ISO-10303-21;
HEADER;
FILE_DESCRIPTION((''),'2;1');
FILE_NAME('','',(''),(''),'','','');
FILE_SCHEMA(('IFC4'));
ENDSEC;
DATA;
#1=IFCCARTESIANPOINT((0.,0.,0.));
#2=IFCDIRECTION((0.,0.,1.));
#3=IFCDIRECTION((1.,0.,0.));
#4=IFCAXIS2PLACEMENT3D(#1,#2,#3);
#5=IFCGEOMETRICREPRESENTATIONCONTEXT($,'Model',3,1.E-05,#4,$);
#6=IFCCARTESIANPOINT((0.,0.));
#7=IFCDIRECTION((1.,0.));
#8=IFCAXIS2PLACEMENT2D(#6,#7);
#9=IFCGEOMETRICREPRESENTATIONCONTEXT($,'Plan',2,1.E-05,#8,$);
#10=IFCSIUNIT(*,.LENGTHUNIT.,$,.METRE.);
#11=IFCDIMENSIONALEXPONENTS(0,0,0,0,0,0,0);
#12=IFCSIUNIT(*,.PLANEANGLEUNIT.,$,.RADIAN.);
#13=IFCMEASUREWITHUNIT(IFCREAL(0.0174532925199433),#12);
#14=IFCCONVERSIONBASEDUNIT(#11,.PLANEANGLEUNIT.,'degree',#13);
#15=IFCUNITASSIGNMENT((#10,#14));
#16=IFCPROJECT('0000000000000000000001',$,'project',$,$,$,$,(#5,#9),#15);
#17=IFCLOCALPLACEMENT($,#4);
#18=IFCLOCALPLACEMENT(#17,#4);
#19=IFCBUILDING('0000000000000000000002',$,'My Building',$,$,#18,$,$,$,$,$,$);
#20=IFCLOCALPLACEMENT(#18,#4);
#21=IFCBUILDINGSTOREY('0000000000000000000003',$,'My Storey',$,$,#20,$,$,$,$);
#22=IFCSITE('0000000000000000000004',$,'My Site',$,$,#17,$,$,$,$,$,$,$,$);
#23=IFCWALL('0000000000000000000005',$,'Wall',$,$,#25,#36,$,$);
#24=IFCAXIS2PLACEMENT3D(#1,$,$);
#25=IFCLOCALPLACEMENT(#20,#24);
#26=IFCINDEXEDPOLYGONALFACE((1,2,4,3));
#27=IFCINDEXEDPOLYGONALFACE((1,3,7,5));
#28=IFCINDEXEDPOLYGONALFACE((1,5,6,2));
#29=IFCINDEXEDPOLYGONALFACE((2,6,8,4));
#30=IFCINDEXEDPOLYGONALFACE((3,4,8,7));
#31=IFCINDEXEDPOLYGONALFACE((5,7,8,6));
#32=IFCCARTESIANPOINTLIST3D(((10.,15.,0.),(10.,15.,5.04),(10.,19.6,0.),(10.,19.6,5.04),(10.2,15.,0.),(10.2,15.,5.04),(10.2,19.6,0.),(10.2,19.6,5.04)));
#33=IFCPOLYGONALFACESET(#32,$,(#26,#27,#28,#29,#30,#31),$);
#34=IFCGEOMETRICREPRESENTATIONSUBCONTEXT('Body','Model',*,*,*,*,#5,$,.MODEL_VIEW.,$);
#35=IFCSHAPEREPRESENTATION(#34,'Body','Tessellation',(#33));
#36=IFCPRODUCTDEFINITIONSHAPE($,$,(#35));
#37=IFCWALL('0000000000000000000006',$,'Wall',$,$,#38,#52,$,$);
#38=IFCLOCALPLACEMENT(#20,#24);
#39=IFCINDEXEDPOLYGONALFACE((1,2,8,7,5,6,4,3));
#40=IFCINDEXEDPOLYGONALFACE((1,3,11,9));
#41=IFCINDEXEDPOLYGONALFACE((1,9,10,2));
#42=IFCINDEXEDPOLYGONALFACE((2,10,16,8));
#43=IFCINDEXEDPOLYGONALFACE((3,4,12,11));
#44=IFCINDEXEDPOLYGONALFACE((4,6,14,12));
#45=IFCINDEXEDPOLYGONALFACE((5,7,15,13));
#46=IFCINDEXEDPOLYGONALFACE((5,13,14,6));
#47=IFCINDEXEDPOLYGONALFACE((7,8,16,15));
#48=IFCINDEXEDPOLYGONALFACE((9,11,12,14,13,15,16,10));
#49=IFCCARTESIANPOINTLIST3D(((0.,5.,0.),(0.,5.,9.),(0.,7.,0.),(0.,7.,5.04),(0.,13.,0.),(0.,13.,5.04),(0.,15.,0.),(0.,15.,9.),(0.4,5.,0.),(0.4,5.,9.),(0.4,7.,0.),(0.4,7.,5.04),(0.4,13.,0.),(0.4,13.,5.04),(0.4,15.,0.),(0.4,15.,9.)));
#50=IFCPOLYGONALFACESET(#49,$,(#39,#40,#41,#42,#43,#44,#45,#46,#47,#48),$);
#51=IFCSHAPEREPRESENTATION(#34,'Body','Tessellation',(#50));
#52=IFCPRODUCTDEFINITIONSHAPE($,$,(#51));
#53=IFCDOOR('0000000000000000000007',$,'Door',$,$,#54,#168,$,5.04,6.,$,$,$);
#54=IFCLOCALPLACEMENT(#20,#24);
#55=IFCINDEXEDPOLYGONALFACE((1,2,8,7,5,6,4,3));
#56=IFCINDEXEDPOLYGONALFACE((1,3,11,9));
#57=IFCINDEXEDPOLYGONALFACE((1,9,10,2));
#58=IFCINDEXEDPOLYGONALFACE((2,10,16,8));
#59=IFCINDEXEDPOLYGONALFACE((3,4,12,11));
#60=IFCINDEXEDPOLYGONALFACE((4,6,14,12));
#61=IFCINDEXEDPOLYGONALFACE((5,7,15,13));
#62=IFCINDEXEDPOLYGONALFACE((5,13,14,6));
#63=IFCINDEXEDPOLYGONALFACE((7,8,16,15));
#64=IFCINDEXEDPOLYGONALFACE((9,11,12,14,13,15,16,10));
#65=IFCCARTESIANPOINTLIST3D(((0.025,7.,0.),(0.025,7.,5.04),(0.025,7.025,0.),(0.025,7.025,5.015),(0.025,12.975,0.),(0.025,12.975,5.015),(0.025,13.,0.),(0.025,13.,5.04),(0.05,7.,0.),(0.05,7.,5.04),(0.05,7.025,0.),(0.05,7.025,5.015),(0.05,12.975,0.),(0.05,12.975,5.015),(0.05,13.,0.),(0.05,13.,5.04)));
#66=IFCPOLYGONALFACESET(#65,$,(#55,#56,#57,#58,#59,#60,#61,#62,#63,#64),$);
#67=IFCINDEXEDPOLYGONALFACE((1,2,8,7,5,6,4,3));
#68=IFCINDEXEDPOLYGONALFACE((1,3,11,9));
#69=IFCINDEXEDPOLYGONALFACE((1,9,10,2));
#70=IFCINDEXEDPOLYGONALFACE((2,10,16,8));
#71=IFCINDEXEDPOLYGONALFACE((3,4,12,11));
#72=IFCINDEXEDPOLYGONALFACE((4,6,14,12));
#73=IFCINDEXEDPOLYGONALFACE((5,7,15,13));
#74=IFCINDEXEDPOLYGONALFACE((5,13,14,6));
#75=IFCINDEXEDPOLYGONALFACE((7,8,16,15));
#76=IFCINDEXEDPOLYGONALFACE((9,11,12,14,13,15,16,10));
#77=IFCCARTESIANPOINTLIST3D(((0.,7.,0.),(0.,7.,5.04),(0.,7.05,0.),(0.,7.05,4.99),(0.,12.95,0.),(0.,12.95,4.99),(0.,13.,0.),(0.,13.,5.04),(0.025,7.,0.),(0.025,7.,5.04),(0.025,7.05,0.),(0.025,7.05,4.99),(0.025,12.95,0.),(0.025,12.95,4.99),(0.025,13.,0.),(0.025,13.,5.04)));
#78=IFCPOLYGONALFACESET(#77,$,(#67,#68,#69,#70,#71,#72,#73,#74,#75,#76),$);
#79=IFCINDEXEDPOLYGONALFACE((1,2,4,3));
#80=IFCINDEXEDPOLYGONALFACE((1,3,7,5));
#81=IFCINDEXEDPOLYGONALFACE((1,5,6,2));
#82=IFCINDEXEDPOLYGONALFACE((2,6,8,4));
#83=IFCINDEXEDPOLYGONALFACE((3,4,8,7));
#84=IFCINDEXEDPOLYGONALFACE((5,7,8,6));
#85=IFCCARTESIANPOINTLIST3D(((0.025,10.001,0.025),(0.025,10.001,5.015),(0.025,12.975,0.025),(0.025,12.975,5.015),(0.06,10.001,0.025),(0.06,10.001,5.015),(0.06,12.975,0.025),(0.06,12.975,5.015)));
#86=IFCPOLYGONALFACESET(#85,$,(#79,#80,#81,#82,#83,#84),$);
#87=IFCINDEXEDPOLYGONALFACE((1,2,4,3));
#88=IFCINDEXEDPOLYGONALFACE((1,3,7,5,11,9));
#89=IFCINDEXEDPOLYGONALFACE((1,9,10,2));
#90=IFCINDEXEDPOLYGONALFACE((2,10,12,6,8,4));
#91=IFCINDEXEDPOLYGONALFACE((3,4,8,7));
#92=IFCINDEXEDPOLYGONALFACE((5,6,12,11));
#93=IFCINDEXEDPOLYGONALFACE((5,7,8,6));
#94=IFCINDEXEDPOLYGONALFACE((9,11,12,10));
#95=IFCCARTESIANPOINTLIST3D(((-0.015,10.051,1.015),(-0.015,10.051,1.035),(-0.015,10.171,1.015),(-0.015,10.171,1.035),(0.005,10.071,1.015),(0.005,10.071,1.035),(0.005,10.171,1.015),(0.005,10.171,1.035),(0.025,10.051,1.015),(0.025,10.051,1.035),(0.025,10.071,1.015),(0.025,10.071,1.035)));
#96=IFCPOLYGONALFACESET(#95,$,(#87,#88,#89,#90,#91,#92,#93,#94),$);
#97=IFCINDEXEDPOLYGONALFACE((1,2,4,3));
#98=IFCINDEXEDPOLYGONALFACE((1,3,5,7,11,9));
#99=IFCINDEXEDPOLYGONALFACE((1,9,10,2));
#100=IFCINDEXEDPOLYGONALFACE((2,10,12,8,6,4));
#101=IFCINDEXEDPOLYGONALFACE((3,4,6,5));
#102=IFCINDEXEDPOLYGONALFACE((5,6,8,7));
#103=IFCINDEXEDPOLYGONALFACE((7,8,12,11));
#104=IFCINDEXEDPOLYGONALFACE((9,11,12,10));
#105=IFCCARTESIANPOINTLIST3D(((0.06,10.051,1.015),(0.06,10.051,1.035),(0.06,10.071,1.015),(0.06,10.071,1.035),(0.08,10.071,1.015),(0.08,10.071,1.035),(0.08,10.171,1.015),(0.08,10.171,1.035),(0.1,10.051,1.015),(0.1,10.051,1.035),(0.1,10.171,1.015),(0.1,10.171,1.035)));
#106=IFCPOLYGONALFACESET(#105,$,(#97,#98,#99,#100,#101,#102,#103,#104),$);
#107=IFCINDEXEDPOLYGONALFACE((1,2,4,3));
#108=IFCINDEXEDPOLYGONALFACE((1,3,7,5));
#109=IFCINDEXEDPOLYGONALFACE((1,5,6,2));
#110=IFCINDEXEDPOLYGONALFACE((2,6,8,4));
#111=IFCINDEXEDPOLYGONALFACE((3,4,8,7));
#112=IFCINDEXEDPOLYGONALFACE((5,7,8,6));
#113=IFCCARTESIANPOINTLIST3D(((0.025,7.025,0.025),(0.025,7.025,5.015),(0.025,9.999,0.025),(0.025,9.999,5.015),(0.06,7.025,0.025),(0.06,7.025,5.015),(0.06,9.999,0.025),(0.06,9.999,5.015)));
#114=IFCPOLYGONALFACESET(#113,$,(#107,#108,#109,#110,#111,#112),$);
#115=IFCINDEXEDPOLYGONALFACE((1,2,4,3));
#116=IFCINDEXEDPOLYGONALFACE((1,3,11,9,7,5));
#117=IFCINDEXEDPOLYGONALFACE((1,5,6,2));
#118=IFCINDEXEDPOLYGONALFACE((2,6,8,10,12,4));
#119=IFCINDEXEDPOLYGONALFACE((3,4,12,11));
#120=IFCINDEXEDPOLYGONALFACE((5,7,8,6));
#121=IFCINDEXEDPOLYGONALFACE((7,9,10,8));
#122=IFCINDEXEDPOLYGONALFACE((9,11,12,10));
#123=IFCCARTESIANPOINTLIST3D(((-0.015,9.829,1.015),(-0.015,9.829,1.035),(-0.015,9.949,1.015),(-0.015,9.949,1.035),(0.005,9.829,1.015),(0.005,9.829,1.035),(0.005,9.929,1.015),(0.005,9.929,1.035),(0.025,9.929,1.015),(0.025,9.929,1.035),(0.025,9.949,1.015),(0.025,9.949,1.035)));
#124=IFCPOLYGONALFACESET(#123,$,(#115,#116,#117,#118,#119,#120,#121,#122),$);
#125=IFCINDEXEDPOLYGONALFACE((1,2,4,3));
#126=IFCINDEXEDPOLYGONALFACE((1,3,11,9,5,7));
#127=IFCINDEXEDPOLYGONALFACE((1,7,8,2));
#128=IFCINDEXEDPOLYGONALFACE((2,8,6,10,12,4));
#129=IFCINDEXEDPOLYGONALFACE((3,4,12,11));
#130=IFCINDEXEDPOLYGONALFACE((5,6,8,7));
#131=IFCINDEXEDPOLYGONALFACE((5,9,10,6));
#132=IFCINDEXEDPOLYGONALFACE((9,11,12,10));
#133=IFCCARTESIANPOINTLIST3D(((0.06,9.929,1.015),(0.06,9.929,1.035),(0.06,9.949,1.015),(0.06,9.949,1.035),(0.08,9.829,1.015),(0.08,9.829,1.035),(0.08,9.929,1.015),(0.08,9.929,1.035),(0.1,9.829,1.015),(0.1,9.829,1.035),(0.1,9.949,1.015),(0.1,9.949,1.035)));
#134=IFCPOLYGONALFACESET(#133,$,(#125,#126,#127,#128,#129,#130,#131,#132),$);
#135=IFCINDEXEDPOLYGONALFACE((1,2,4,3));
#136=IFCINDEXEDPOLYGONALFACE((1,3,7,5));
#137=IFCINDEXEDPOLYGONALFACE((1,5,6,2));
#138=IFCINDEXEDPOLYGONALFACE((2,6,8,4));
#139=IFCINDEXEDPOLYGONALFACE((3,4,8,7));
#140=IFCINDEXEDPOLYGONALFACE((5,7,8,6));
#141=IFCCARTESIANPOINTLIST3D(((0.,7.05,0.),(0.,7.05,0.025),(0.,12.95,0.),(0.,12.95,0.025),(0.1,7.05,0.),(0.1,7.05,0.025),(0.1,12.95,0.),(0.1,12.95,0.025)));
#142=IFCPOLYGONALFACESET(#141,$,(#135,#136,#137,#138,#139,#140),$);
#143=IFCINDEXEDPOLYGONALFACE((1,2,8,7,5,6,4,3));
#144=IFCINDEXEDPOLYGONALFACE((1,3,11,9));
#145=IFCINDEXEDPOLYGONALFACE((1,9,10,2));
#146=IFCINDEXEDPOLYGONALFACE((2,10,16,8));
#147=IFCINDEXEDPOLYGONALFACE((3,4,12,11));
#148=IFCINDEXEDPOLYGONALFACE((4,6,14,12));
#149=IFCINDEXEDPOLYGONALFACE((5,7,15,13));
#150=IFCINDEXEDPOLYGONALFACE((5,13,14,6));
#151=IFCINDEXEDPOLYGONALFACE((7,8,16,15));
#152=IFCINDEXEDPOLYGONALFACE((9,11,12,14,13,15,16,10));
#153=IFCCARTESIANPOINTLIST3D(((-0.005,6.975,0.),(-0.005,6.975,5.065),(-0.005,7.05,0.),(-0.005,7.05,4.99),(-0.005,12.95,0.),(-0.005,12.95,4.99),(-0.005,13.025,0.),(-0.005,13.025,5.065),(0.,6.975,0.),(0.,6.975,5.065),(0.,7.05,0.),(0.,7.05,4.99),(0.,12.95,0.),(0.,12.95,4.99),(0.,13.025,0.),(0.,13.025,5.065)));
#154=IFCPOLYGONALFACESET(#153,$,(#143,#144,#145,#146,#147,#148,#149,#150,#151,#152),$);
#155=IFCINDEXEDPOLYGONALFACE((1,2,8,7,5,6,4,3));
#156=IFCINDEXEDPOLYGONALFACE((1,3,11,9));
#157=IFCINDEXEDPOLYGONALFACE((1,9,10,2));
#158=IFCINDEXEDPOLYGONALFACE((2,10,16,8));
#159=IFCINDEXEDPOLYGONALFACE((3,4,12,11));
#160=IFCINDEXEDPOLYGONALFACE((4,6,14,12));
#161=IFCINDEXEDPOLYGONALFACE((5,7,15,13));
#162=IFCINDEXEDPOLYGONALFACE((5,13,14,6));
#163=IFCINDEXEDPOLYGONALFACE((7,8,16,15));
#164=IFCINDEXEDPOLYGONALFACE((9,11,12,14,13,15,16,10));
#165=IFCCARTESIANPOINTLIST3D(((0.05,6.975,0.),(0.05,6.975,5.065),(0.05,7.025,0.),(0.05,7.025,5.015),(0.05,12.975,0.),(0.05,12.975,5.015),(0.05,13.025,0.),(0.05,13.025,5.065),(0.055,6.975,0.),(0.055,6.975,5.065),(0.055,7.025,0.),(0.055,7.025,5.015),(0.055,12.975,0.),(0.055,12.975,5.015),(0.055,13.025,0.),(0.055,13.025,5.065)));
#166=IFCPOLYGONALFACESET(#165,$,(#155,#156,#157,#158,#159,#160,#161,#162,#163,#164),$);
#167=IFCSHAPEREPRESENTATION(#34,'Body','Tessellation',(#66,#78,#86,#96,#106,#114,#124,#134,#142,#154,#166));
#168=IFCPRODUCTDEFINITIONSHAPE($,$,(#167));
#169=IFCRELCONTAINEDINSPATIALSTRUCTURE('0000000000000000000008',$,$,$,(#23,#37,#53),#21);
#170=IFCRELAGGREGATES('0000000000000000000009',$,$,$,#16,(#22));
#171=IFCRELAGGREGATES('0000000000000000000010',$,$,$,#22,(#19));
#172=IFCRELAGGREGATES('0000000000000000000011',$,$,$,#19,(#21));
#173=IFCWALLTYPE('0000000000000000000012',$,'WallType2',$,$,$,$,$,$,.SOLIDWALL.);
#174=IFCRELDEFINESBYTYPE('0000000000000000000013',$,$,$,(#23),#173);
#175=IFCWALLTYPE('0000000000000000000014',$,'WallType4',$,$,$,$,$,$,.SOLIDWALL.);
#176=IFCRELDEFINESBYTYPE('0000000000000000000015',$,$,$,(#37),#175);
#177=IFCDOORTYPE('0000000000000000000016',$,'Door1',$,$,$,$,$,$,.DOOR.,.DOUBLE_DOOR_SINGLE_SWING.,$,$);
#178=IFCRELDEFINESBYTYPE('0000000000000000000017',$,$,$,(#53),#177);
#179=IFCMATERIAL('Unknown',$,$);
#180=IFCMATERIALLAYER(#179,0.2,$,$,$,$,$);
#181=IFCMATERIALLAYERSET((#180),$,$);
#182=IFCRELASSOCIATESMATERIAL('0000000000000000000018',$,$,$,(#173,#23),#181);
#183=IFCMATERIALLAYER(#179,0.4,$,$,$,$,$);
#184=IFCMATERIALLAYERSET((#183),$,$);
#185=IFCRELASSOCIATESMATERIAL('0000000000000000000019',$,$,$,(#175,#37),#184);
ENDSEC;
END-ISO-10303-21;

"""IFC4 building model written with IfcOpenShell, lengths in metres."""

from ifc_helpers import new_model, entity, si_unit, converted_unit, frame, origin_with_axes, origin_2d_with_axis, place, context, subcontext, project, spatial, line, indexed_curve, outline, extrude, shape, source, transform, mapped, material, layer, layer_set, layer_usage, type_object, type_shapes, element, fill, save


model = new_model("IFC4")

# Units and contexts
model_context = context("Model", 3, precision=1e-05, world=origin_with_axes())
plan_context = context("Plan", 2, precision=1e-05, world=origin_2d_with_axis())
body_context_1 = subcontext(model_context, "Body", "Model", "MODEL_VIEW")
body_context_2 = subcontext(plan_context, "Body", "Plan", "PLAN_VIEW")
ifc_project = project(units=[si_unit("LENGTHUNIT", "METRE"), converted_unit("PLANEANGLEUNIT", "degree", entity("IfcReal", 0.0174532925199433), si_unit("PLANEANGLEUNIT", "RADIAN"), dimensions=[0, 0, 0, 0, 0, 0, 0])], contexts=[model_context, plan_context])

# Site, building, storey
site_placement = place(None, origin_with_axes())
site = spatial("IfcSite", under=ifc_project, at=site_placement, Name="My Site")
building_placement = place(site_placement, origin_with_axes())
building = spatial("IfcBuilding", under=site, at=building_placement, Name="My Building")
storey_placement = place(building_placement, origin_with_axes())
storey = spatial("IfcBuildingStorey", under=building, at=storey_placement, Name="My Storey")

# Wall
ifc_material = material(Name="Unknown")
ifc_layer_1 = layer(ifc_material, 0.2)
ifc_layer_set_1 = layer_set([ifc_layer_1])
ifc_layer_usage_1 = layer_usage(ifc_layer_set_1, "AXIS2", "POSITIVE", 0.0)
wall_type_1 = type_object("IfcWallType", Name="WallType2", PredefinedType="SOLIDWALL", material=ifc_layer_set_1)
wall_1_placement = place(storey_placement, frame((10.2, 15.0, 0.0), z_axis=(0.0, 0.0, 1.0), x_axis=(0.0, 1.0, 0.0)))
element("IfcWall", 1, at=wall_1_placement, inside=storey, type_object=wall_type_1, material=ifc_layer_usage_1, Name="Wall", context=body_context_1, shape_type="SweptSolid", body=[
    extrude(outline(indexed_curve([(0.0, 0.0), (0.0, 0.2), (4.6, 0.2), (4.6, 0.0), (0.0, 0.0)], self_intersect=False)), origin_with_axes(), (0.0, 0.0, 1.0), 5.04),
])

# Shared definitions
ifc_layer_2 = layer(ifc_material, 0.4)
ifc_layer_set_2 = layer_set([ifc_layer_2])
wall_type_2 = type_object("IfcWallType", Name="WallType4", PredefinedType="SOLIDWALL", material=ifc_layer_set_2)

# Wall, opening, door
ifc_layer_usage_2 = layer_usage(ifc_layer_set_2, "AXIS2", "POSITIVE", 0.0)
wall_2_placement = place(storey_placement, frame((0.0, 15.0, 0.0), z_axis=(0.0, 0.0, 1.0), x_axis=(0.0, -1.0, 0.0)))
wall_2 = element("IfcWall", 2, at=wall_2_placement, inside=storey, type_object=wall_type_2, material=ifc_layer_usage_2, Name="Wall", context=body_context_1, shape_type="SweptSolid", body=[
    extrude(outline(indexed_curve([(0.0, 0.0), (0.0, 0.4), (10.0, 0.4), (10.0, 0.0), (0.0, 0.0)], self_intersect=False)), origin_with_axes(), (0.0, 0.0, 1.0), 9.0),
])
shared_shape_1 = source(origin_with_axes(), body_context_1, "Body", "SweptSolid", [
    extrude(outline(indexed_curve([(0.0, 0.0), (6.0, 0.0), (6.0, 5.04), (0.0, 5.04)], segments=[line(1, 2, 3, 4, 1)])), frame((0.0, -0.1, 0.0), z_axis=(0.0, -1.0, 0.0), x_axis=(1.0, 0.0, 0.0)), (0.0, 0.0, -1.0), 0.6),
])
opening_1_placement = place(wall_2_placement, frame((2.0, 0.0, 0.0), z_axis=(0.0, 0.0, 1.0), x_axis=(1.0, 0.0, 0.0)))
opening_1 = element("IfcOpeningElement", 3, at=opening_1_placement, cuts=wall_2, PredefinedType="OPENING", context=body_context_1, shape_type="MappedRepresentation", body=[
    mapped(shared_shape_1, transform((0.0, 0.0, 0.0), x_axis=(1.0, 0.0, 0.0), y_axis=(0.0, 1.0, 0.0), z_axis=(0.0, 0.0, 1.0), scale=1.0)),
])
door_type_1 = type_object("IfcDoorType", Name="Door1", OperationType="DOUBLE_DOOR_SINGLE_SWING", PredefinedType="DOOR")
shared_shape_2 = source(origin_with_axes(), body_context_1, "Body", "SweptSolid", [
    extrude(outline(indexed_curve([(0.0, 0.0), (0.0, 5.04), (6.0, 5.04), (6.0, 0.0), (5.975, 0.0), (5.975, 5.015), (0.025, 5.015), (0.025, 0.0)], segments=[line(1, 2, 3, 4, 5, 6, 7, 8, 1)])), frame((0.0, 0.025, 0.0), z_axis=(0.0, -1.0, 0.0), x_axis=(1.0, 0.0, 0.0)), (0.0, 0.0, -1.0), 0.025),
    extrude(outline(indexed_curve([(0.0, 0.0), (0.0, 5.04), (6.0, 5.04), (6.0, 0.0), (5.95, 0.0), (5.95, 4.99), (0.05, 4.99), (0.05, 0.0)], segments=[line(1, 2, 3, 4, 5, 6, 7, 8, 1)])), frame((0.0, 0.0, 0.0), z_axis=(0.0, -1.0, 0.0), x_axis=(1.0, 0.0, 0.0)), (0.0, 0.0, -1.0), 0.025),
    extrude(outline(indexed_curve([(0.0, 0.0), (2.974, 0.0), (2.974, 0.035), (0.0, 0.035)], segments=[line(1, 2, 3, 4, 1)])), frame((0.025, 0.025, 0.025), z_axis=(0.0, 0.0, 1.0), x_axis=(1.0, 0.0, 0.0)), (0.0, 0.0, 1.0), 4.99),
    extrude(outline(indexed_curve([(0.0, 0.0), (0.0, -0.04), (-0.12, -0.04), (-0.12, -0.02), (-0.02, -0.02), (-0.02, 0.0)], segments=[line(1, 2, 3, 4, 5, 6, 1)])), frame((2.949, 0.025, 1.015), z_axis=(0.0, 0.0, 1.0), x_axis=(1.0, 0.0, 0.0)), (0.0, 0.0, 1.0), 0.02),
    extrude(outline(indexed_curve([(0.0, 0.0), (0.0, 0.04), (-0.12, 0.04), (-0.12, 0.02), (-0.02, 0.02), (-0.02, 0.0)], segments=[line(1, 2, 3, 4, 5, 6, 1)])), frame((2.949, 0.06, 1.015), z_axis=(0.0, 0.0, 1.0), x_axis=(1.0, 0.0, 0.0)), (0.0, 0.0, 1.0), 0.02),
    extrude(outline(indexed_curve([(0.0, 0.0), (-2.974, 0.0), (-2.974, 0.035), (0.0, 0.035)], segments=[line(1, 2, 3, 4, 1)])), frame((5.975, 0.025, 0.025), z_axis=(0.0, 0.0, 1.0), x_axis=(1.0, 0.0, 0.0)), (0.0, 0.0, 1.0), 4.99),
    extrude(outline(indexed_curve([(0.0, 0.0), (0.0, -0.04), (0.12, -0.04), (0.12, -0.02), (0.02, -0.02), (0.02, 0.0)], segments=[line(1, 2, 3, 4, 5, 6, 1)])), frame((3.051, 0.025, 1.015), z_axis=(0.0, 0.0, 1.0), x_axis=(1.0, 0.0, 0.0)), (0.0, 0.0, 1.0), 0.02),
    extrude(outline(indexed_curve([(0.0, 0.0), (0.0, 0.04), (0.12, 0.04), (0.12, 0.02), (0.02, 0.02), (0.02, 0.0)], segments=[line(1, 2, 3, 4, 5, 6, 1)])), frame((3.051, 0.06, 1.015), z_axis=(0.0, 0.0, 1.0), x_axis=(1.0, 0.0, 0.0)), (0.0, 0.0, 1.0), 0.02),
    extrude(outline(indexed_curve([(0.0, 0.0), (5.9, 0.0), (5.9, 0.1), (0.0, 0.1)], segments=[line(1, 2, 3, 4, 1)])), frame((0.05, 0.0, 0.0), z_axis=(0.0, 0.0, 1.0), x_axis=(1.0, 0.0, 0.0)), (0.0, 0.0, 1.0), 0.025),
    extrude(outline(indexed_curve([(0.0, 0.0), (0.0, 5.065), (6.05, 5.065), (6.05, 0.0), (5.975, 0.0), (5.975, 4.99), (0.075, 4.99), (0.075, 0.0)], segments=[line(1, 2, 3, 4, 5, 6, 7, 8, 1)])), frame((-0.025, -0.005, 0.0), z_axis=(0.0, -1.0, 0.0), x_axis=(1.0, 0.0, 0.0)), (0.0, 0.0, -1.0), 0.005),
    extrude(outline(indexed_curve([(0.0, 0.0), (0.0, 5.065), (6.05, 5.065), (6.05, 0.0), (6.0, 0.0), (6.0, 5.015), (0.05, 5.015), (0.05, 0.0)], segments=[line(1, 2, 3, 4, 5, 6, 7, 8, 1)])), frame((-0.025, 0.05, 0.0), z_axis=(0.0, -1.0, 0.0), x_axis=(1.0, 0.0, 0.0)), (0.0, 0.0, -1.0), 0.005),
])
shared_shape_3 = source(origin_with_axes(), body_context_2, "Body", "Curve2D", [
    entity("IfcIndexedPolyCurve", entity("IfcCartesianPointList2D", [[0.0, 0.0], [0.0, 0.05], [0.025, 0.05], [0.025, 0.025], [0.05, 0.025], [0.05, 0.0]]), [entity("IfcLineIndex", [1, 2, 3, 4, 5, 6, 1])]),
    entity("IfcIndexedPolyCurve", entity("IfcCartesianPointList2D", [[6.0, 0.0], [6.0, 0.05], [5.975, 0.05], [5.975, 0.025], [5.95, 0.025], [5.95, 0.0]]), [entity("IfcLineIndex", [1, 2, 3, 4, 5, 6, 1])]),
    entity("IfcTrimmedCurve", entity("IfcEllipse", entity("IfcAxis2Placement2D", entity("IfcCartesianPoint", [0.06, 0.05]), entity("IfcDirection", [1.0, 0.0])), 2.94, 2.975), [entity("IfcCartesianPoint", [3.0, 0.05])], [entity("IfcCartesianPoint", [0.06, 3.025])], True, "CARTESIAN"),
    entity("IfcIndexedPolyCurve", entity("IfcCartesianPointList2D", [[0.025, 0.05], [0.06, 0.05], [0.06, 3.025], [0.025, 3.025]]), [entity("IfcLineIndex", [1, 2, 3, 4, 1])]),
    entity("IfcTrimmedCurve", entity("IfcEllipse", entity("IfcAxis2Placement2D", entity("IfcCartesianPoint", [5.94, 0.05]), entity("IfcDirection", [1.0, 0.0])), 2.94, 2.975), [entity("IfcCartesianPoint", [5.94, 3.025])], [entity("IfcCartesianPoint", [3.0, 0.05])], True, "CARTESIAN"),
    entity("IfcIndexedPolyCurve", entity("IfcCartesianPointList2D", [[5.975, 0.05], [5.94, 0.05], [5.94, 3.025], [5.975, 3.025]]), [entity("IfcLineIndex", [1, 2, 3, 4, 1])]),
])
type_shapes(door_type_1, [shared_shape_2, shared_shape_3])
door_1_placement = place(opening_1_placement, frame((0.0, 0.0, 0.0), z_axis=(0.0, 0.0, 1.0), x_axis=(1.0, 0.0, 0.0)))
door_1 = element("IfcDoor", 4, at=door_1_placement, inside=storey, type_object=door_type_1, Name="Door", OverallHeight=5.04, OverallWidth=6.0, shapes=[
    shape(body_context_1, "Body", "MappedRepresentation", [mapped(shared_shape_2, transform((0.0, 0.0, 0.0), x_axis=(1.0, 0.0, 0.0), y_axis=(0.0, 1.0, 0.0), z_axis=(0.0, 0.0, 1.0), scale=1.0))]),
    shape(body_context_2, "Body", "MappedRepresentation", [mapped(shared_shape_3, transform((0.0, 0.0, 0.0), x_axis=(1.0, 0.0, 0.0), y_axis=(0.0, 1.0, 0.0), z_axis=(0.0, 0.0, 1.0), scale=1.0))]),
])
fill(opening_1, door_1)

save(model, "model.ifc")
